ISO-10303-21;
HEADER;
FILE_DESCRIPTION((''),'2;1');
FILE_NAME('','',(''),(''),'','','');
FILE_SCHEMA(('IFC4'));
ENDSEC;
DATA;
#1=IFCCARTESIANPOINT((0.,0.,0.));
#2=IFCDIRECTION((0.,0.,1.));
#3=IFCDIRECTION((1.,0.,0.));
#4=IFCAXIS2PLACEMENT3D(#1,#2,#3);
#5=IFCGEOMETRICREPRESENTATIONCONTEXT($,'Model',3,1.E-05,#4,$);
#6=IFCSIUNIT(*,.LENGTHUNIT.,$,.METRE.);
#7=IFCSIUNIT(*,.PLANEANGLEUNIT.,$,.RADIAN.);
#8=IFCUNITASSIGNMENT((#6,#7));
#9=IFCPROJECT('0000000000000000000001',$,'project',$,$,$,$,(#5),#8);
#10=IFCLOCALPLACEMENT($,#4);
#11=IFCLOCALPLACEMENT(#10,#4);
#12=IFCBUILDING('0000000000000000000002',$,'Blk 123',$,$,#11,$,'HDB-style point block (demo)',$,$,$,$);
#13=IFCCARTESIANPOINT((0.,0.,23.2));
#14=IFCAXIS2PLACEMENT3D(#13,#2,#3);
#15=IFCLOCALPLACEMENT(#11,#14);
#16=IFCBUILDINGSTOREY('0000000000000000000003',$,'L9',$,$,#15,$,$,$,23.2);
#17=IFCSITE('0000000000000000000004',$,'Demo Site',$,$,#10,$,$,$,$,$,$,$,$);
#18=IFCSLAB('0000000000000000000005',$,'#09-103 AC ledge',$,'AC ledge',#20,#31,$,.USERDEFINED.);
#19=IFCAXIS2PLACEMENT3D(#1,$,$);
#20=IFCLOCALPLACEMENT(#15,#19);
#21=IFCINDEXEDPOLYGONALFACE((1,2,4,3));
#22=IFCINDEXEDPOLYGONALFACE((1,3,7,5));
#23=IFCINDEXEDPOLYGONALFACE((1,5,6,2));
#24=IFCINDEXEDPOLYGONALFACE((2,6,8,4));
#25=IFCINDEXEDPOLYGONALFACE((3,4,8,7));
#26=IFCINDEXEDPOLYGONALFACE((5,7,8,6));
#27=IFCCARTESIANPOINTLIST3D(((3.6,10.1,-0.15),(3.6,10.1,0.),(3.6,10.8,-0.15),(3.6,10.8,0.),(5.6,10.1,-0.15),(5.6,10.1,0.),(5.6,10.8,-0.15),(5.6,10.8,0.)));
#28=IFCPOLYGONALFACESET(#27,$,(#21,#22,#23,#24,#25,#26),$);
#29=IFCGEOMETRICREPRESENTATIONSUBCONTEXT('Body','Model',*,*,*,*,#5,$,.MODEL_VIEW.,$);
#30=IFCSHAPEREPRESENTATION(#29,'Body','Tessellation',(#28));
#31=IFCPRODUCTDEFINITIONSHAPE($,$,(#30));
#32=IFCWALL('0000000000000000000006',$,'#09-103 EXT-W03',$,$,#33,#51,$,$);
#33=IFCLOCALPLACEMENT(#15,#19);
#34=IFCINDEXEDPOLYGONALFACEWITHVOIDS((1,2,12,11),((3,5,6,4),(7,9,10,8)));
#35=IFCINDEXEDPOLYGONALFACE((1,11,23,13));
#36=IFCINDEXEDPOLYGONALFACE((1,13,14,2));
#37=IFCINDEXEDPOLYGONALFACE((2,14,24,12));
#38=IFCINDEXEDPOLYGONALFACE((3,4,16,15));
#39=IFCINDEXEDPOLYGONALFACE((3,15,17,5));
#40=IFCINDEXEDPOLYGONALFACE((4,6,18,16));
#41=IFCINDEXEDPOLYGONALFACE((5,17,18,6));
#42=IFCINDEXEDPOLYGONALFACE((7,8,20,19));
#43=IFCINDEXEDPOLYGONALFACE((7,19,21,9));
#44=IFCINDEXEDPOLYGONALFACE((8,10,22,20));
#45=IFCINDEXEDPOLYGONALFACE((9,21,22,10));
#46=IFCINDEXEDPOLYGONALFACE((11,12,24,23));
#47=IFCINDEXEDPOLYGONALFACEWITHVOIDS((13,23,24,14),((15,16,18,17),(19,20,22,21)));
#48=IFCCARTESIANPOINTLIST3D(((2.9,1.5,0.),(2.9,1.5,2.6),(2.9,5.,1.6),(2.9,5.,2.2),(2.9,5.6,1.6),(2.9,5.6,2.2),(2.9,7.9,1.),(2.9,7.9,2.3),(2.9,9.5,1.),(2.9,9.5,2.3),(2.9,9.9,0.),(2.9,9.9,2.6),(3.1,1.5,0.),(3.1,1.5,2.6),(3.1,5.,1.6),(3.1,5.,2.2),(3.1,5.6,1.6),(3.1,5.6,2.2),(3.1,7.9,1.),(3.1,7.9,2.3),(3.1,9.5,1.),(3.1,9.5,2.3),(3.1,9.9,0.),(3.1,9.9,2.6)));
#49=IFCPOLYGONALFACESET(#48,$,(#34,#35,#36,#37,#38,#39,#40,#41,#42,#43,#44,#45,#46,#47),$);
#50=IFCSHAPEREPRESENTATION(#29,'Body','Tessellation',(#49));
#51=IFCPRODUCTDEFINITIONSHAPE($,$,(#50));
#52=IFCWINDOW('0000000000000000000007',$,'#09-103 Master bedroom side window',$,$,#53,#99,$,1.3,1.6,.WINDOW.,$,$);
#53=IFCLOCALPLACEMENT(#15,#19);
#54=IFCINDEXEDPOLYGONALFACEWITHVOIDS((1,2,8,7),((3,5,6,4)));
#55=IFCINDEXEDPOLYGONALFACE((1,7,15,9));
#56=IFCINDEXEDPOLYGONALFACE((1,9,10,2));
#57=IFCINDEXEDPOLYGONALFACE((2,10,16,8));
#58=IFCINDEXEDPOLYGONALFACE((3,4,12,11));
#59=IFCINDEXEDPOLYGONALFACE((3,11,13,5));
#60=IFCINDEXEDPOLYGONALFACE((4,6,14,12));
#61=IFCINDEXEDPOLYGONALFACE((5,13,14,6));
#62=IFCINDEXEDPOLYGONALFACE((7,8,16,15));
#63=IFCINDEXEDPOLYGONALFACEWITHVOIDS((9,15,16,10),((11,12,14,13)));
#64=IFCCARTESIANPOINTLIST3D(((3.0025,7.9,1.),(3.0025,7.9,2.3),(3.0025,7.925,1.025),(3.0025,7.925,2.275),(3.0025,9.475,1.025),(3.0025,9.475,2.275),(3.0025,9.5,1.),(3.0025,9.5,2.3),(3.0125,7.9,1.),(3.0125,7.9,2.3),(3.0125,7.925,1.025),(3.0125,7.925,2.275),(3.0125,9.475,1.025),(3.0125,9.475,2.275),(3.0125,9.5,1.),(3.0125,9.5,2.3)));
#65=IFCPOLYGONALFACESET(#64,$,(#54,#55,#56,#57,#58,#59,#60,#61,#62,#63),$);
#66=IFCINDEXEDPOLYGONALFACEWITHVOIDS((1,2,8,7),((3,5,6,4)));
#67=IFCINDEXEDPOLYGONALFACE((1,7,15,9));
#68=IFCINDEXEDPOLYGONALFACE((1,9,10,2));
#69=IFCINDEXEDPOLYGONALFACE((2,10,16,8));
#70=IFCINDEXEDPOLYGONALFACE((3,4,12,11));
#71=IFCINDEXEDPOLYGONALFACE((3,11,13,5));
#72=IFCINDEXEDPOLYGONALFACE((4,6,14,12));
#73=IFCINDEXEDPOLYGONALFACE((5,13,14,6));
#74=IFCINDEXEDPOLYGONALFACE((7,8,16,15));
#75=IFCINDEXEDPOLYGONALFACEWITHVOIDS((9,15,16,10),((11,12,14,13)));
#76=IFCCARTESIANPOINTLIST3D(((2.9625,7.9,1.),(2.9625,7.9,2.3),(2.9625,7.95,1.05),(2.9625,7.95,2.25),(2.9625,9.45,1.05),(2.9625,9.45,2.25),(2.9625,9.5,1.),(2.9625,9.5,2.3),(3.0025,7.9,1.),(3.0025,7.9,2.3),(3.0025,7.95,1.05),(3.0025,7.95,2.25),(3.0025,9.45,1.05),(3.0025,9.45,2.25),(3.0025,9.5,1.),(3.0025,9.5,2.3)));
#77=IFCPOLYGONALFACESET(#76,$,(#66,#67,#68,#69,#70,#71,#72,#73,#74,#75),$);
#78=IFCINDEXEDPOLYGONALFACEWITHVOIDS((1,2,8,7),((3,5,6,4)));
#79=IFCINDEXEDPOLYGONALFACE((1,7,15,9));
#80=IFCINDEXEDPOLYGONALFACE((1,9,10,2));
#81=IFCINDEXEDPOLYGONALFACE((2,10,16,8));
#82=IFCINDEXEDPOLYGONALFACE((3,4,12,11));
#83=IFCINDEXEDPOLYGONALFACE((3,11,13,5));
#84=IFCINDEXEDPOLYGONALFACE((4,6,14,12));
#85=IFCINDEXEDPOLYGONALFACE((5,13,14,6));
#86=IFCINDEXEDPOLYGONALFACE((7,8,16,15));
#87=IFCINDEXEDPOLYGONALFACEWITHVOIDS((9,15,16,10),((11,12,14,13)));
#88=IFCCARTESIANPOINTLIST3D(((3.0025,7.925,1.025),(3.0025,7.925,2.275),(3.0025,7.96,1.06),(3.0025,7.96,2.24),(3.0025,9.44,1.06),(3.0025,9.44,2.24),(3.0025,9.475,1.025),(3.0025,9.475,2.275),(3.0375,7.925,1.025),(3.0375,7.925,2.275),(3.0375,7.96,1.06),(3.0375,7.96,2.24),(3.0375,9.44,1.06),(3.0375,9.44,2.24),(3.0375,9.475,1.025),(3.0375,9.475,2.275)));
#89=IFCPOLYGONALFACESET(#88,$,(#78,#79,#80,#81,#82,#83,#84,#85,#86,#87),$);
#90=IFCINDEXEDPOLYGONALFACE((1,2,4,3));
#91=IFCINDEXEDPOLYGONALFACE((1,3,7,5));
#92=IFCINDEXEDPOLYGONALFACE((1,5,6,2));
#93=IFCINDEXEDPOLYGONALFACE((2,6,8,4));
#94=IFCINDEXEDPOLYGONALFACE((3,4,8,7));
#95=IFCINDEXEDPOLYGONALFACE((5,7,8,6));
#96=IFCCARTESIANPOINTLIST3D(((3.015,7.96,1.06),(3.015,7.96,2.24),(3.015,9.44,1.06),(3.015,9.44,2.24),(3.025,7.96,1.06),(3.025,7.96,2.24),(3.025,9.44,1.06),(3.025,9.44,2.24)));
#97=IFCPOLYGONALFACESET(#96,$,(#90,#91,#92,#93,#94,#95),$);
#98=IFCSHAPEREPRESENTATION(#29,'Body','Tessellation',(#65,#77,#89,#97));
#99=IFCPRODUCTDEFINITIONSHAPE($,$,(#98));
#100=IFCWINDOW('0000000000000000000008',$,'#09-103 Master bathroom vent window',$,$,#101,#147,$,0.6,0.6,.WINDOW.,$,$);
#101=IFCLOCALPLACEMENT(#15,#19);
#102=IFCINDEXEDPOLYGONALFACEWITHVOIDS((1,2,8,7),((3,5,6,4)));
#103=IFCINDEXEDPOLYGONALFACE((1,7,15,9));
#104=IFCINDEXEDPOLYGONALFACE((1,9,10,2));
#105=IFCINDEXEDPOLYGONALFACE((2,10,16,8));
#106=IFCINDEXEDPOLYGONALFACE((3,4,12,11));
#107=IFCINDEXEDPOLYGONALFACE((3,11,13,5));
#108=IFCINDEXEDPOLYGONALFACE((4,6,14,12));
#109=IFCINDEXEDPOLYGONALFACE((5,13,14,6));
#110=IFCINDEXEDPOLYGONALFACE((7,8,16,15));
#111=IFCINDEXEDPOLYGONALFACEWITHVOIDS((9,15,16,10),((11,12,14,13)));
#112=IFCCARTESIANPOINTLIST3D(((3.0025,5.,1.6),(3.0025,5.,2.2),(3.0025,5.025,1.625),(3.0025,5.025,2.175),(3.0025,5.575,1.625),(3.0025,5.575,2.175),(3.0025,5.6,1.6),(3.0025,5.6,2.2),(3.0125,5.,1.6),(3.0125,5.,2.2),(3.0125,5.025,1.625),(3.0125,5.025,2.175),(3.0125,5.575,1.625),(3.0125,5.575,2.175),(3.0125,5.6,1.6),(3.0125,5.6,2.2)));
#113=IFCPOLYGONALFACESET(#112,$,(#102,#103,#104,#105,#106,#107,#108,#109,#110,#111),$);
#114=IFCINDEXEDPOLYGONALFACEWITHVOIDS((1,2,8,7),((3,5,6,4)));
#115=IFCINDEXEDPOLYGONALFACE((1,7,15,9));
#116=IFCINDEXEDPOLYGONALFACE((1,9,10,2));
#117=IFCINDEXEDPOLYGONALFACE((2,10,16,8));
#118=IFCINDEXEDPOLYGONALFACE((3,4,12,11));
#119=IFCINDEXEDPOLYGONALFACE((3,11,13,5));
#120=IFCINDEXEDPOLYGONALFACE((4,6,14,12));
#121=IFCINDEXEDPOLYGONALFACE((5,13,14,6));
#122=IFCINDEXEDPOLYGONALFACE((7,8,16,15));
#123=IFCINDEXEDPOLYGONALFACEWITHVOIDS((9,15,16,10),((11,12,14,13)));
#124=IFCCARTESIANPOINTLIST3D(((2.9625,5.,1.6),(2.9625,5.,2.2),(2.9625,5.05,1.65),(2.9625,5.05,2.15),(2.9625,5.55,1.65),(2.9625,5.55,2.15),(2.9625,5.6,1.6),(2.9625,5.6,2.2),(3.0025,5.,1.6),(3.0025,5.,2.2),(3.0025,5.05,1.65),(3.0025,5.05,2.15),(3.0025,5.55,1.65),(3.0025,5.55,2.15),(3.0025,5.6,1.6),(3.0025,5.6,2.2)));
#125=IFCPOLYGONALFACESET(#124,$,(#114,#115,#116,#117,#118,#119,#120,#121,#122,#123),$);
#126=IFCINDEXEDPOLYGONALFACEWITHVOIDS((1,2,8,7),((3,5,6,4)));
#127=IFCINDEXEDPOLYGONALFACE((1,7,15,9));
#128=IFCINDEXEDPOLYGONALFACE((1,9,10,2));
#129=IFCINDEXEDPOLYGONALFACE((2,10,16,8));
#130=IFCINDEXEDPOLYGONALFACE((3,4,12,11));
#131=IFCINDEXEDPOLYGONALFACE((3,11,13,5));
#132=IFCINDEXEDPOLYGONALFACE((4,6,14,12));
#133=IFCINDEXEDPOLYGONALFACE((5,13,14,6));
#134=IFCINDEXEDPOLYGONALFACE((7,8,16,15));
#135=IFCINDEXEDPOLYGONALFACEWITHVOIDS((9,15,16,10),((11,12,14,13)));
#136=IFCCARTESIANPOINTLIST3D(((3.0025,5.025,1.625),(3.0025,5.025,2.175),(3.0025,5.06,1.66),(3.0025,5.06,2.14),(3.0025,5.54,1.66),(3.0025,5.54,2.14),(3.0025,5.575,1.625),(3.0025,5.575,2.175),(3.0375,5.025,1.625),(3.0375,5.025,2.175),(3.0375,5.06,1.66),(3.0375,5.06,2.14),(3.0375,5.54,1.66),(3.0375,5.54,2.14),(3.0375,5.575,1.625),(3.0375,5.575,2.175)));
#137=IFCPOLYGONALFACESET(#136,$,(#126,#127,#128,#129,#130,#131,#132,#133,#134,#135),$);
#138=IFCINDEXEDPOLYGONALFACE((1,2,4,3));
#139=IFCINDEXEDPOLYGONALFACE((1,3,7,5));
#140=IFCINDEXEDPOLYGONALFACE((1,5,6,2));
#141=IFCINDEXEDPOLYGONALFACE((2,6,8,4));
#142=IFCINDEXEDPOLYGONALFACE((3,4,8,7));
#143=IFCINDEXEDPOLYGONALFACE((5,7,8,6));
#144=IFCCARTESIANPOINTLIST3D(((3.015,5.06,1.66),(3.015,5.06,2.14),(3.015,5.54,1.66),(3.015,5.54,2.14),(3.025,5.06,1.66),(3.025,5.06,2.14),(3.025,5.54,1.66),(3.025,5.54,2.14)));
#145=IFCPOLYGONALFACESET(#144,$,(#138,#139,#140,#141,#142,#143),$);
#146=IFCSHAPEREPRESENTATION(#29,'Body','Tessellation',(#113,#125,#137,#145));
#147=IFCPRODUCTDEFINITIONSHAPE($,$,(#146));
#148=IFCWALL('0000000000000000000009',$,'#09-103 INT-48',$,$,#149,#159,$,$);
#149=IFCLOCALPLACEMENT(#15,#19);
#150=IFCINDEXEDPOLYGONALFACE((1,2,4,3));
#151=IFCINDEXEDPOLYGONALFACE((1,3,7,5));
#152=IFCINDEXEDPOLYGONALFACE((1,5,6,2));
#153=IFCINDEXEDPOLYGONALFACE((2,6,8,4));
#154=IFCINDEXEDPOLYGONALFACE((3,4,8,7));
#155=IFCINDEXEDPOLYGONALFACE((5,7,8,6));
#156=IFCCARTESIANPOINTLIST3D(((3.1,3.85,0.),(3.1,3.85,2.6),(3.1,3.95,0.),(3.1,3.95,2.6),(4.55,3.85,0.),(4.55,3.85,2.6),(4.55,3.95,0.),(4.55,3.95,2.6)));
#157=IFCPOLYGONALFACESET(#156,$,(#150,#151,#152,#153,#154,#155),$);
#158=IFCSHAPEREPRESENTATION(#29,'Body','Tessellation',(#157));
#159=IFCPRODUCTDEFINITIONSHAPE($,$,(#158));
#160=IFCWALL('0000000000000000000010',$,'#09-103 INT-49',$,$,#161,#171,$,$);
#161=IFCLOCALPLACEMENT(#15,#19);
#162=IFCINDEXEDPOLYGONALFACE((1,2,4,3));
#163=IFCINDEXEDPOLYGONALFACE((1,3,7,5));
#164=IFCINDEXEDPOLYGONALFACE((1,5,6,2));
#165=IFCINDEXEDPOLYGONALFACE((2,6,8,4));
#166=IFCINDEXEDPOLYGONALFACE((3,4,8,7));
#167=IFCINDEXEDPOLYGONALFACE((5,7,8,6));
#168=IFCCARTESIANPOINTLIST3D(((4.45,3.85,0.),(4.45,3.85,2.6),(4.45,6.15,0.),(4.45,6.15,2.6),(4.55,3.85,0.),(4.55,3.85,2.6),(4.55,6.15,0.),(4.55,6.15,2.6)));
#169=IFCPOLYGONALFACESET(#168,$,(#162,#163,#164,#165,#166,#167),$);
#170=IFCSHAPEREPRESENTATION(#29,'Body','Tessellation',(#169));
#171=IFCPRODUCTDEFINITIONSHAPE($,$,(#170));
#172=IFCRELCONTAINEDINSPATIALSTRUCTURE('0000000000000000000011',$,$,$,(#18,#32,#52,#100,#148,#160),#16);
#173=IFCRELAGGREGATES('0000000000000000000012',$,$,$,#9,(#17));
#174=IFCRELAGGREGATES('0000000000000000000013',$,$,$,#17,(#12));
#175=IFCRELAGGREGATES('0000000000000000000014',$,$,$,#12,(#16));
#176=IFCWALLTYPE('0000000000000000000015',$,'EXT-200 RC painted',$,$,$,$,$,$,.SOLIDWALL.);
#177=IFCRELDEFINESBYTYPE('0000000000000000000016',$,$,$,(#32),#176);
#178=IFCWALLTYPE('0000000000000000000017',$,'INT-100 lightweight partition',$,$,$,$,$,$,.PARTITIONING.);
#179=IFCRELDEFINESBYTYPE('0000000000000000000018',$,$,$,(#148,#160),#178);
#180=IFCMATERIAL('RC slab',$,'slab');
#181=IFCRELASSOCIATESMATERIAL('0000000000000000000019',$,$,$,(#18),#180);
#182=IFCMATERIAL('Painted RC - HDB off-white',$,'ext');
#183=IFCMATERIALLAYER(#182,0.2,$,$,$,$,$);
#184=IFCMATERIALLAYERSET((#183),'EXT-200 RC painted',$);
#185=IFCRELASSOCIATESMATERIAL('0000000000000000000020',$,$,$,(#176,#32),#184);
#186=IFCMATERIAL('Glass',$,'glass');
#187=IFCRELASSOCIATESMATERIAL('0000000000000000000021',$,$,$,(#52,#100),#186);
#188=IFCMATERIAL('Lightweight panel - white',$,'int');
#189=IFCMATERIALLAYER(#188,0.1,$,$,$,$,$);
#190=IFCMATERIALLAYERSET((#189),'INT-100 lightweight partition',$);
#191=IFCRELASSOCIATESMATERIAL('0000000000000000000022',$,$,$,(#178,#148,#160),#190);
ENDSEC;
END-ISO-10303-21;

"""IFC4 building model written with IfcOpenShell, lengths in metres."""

from ifc_helpers import new_model, si_unit, frame, origin, origin_with_axes, place, context, subcontext, project, spatial, polyline, line, indexed_curve, outline, extrude, material, layer, layer_set, layer_usage, type_object, element, fill, save


model = new_model("IFC4")

# Units and contexts
model_context = context("Model", 3, precision=1e-05, world=origin_with_axes())
body_context = subcontext(model_context, "Body", "Model", "MODEL_VIEW")
ifc_project = project(units=[si_unit("LENGTHUNIT", "METRE"), si_unit("PLANEANGLEUNIT", "RADIAN")], contexts=[model_context])

# Site, building, storey
site_placement = place(None, origin_with_axes())
site = spatial("IfcSite", under=ifc_project, at=site_placement, Name="Demo Site")
building_placement = place(site_placement, origin_with_axes())
building = spatial("IfcBuilding", under=site, at=building_placement, Name="Blk 123", LongName="HDB-style point block (demo)")
storey_placement = place(building_placement, frame((0.0, 0.0, 23.2), z_axis=(0.0, 0.0, 1.0), x_axis=(1.0, 0.0, 0.0)))
storey = spatial("IfcBuildingStorey", under=building, at=storey_placement, Name="L9", Elevation=23.2)

# Slab
ifc_material_1 = material(Name="RC slab", Category="slab")
slab_placement = place(storey_placement, frame((4.6, 10.45, -0.15), z_axis=(0.0, 0.0, 1.0), x_axis=(1.0, 0.0, 0.0)))
element("IfcSlab", 1, at=slab_placement, inside=storey, material=ifc_material_1, Name="#09-103 AC ledge", ObjectType="AC ledge", PredefinedType="USERDEFINED", context=body_context, shape_type="SweptSolid", body=[
    extrude(outline(polyline([(1.0, -0.35), (1.0, 0.35), (-1.0, 0.35), (-1.0, -0.35), (1.0, -0.35)])), origin(), (0.0, 0.0, 1.0), 0.15),
])

# Wall, openings, windows
ifc_material_2 = material(Name="Painted RC - HDB off-white", Category="ext")
ifc_layer_1 = layer(ifc_material_2, 0.2)
ifc_layer_set_1 = layer_set([ifc_layer_1], Name="EXT-200 RC painted")
ifc_layer_usage_1 = layer_usage(ifc_layer_set_1, "AXIS2", "POSITIVE", 0.0)
wall_type_1 = type_object("IfcWallType", Name="EXT-200 RC painted", PredefinedType="SOLIDWALL", material=ifc_layer_set_1)
wall_1_placement = place(storey_placement, frame((2.9, 9.9, 0.0), z_axis=(0.0, 0.0, 1.0), x_axis=(0.0, -1.0, 0.0)))
wall_1 = element("IfcWall", 2, at=wall_1_placement, inside=storey, type_object=wall_type_1, material=ifc_layer_usage_1, Name="#09-103 EXT-W03", context=body_context, shape_type="SweptSolid", body=[
    extrude(outline(indexed_curve([(0.0, 0.0), (0.0, 0.2), (8.4, 0.2), (8.4, 0.0), (0.0, 0.0)], self_intersect=False)), origin_with_axes(), (0.0, 0.0, 1.0), 2.6),
])
opening_1_placement = place(wall_1_placement, frame((0.4, -0.1, 1.0), z_axis=(0.0, 0.0, 1.0), x_axis=(1.0, 0.0, 0.0)))
opening_1 = element("IfcOpeningElement", 3, at=opening_1_placement, cuts=wall_1, context=body_context, shape_type="SweptSolid", body=[
    extrude(outline(indexed_curve([(0.0, 0.0), (0.0, 0.4), (1.6, 0.4), (1.6, 0.0), (0.0, 0.0)], self_intersect=False)), origin_with_axes(), (0.0, 0.0, 1.0), 1.3),
])
opening_2_placement = place(wall_1_placement, frame((4.3, -0.1, 1.6), z_axis=(0.0, 0.0, 1.0), x_axis=(1.0, 0.0, 0.0)))
opening_2 = element("IfcOpeningElement", 4, at=opening_2_placement, cuts=wall_1, context=body_context, shape_type="SweptSolid", body=[
    extrude(outline(indexed_curve([(0.0, 0.0), (0.0, 0.4), (0.6, 0.4), (0.6, 0.0), (0.0, 0.0)], self_intersect=False)), origin_with_axes(), (0.0, 0.0, 1.0), 0.6),
])
ifc_material_3 = material(Name="Glass", Category="glass")
window_1_placement = place(opening_1_placement, frame((0.0, 0.1125, 0.0), z_axis=(0.0, 0.0, 1.0), x_axis=(1.0, 0.0, 0.0)))
window_1 = element("IfcWindow", 5, at=window_1_placement, inside=storey, material=ifc_material_3, Name="#09-103 Master bedroom side window", OverallHeight=1.3, OverallWidth=1.6, PredefinedType="WINDOW", context=body_context, shape_type="SweptSolid", body=[
    extrude(outline(indexed_curve([(0.0, 0.0), (1.6, 0.0), (1.6, 1.3), (0.0, 1.3)], segments=[line(1, 2, 3, 4, 1)]), holes=[indexed_curve([(0.025, 0.025), (1.575, 0.025), (1.575, 1.275), (0.025, 1.275)], segments=[line(1, 2, 3, 4, 1)])]), frame((0.0, 0.09, 0.0), z_axis=(0.0, -1.0, 0.0), x_axis=(1.0, 0.0, 0.0)), (0.0, 0.0, -1.0), 0.01),
    extrude(outline(indexed_curve([(0.0, 0.0), (1.6, 0.0), (1.6, 1.3), (0.0, 1.3)], segments=[line(1, 2, 3, 4, 1)]), holes=[indexed_curve([(0.05, 0.05), (1.55, 0.05), (1.55, 1.25), (0.05, 1.25)], segments=[line(1, 2, 3, 4, 1)])]), frame((0.0, 0.05, 0.0), z_axis=(0.0, -1.0, 0.0), x_axis=(1.0, 0.0, 0.0)), (0.0, 0.0, -1.0), 0.04),
    extrude(outline(indexed_curve([(0.0, 0.0), (1.55, 0.0), (1.55, 1.25), (0.0, 1.25)], segments=[line(1, 2, 3, 4, 1)]), holes=[indexed_curve([(0.035, 0.035), (1.515, 0.035), (1.515, 1.215), (0.035, 1.215)], segments=[line(1, 2, 3, 4, 1)])]), frame((0.025, 0.09, 0.025), z_axis=(0.0, -1.0, 0.0), x_axis=(1.0, 0.0, 0.0)), (0.0, 0.0, -1.0), 0.035),
    extrude(outline(indexed_curve([(0.035, 0.035), (1.515, 0.035), (1.515, 1.215), (0.035, 1.215)], segments=[line(1, 2, 3, 4, 1)])), frame((0.025, 0.1025, 0.025), z_axis=(0.0, -1.0, 0.0), x_axis=(1.0, 0.0, 0.0)), (0.0, 0.0, -1.0), 0.01),
])
fill(opening_1, window_1)
window_2_placement = place(opening_2_placement, frame((0.0, 0.1125, 0.0), z_axis=(0.0, 0.0, 1.0), x_axis=(1.0, 0.0, 0.0)))
window_2 = element("IfcWindow", 6, at=window_2_placement, inside=storey, material=ifc_material_3, Name="#09-103 Master bathroom vent window", OverallHeight=0.6, OverallWidth=0.6, PredefinedType="WINDOW", context=body_context, shape_type="SweptSolid", body=[
    extrude(outline(indexed_curve([(0.0, 0.0), (0.6, 0.0), (0.6, 0.6), (0.0, 0.6)], segments=[line(1, 2, 3, 4, 1)]), holes=[indexed_curve([(0.025, 0.025), (0.575, 0.025), (0.575, 0.575), (0.025, 0.575)], segments=[line(1, 2, 3, 4, 1)])]), frame((0.0, 0.09, 0.0), z_axis=(0.0, -1.0, 0.0), x_axis=(1.0, 0.0, 0.0)), (0.0, 0.0, -1.0), 0.01),
    extrude(outline(indexed_curve([(0.0, 0.0), (0.6, 0.0), (0.6, 0.6), (0.0, 0.6)], segments=[line(1, 2, 3, 4, 1)]), holes=[indexed_curve([(0.05, 0.05), (0.55, 0.05), (0.55, 0.55), (0.05, 0.55)], segments=[line(1, 2, 3, 4, 1)])]), frame((0.0, 0.05, 0.0), z_axis=(0.0, -1.0, 0.0), x_axis=(1.0, 0.0, 0.0)), (0.0, 0.0, -1.0), 0.04),
    extrude(outline(indexed_curve([(0.0, 0.0), (0.55, 0.0), (0.55, 0.55), (0.0, 0.55)], segments=[line(1, 2, 3, 4, 1)]), holes=[indexed_curve([(0.035, 0.035), (0.515, 0.035), (0.515, 0.515), (0.035, 0.515)], segments=[line(1, 2, 3, 4, 1)])]), frame((0.025, 0.09, 0.025), z_axis=(0.0, -1.0, 0.0), x_axis=(1.0, 0.0, 0.0)), (0.0, 0.0, -1.0), 0.035),
    extrude(outline(indexed_curve([(0.035, 0.035), (0.515, 0.035), (0.515, 0.515), (0.035, 0.515)], segments=[line(1, 2, 3, 4, 1)])), frame((0.025, 0.1025, 0.025), z_axis=(0.0, -1.0, 0.0), x_axis=(1.0, 0.0, 0.0)), (0.0, 0.0, -1.0), 0.01),
])
fill(opening_2, window_2)

# Shared definitions
ifc_material_4 = material(Name="Lightweight panel - white", Category="int")
ifc_layer_2 = layer(ifc_material_4, 0.1)
ifc_layer_set_2 = layer_set([ifc_layer_2], Name="INT-100 lightweight partition")
ifc_layer_usage_2 = layer_usage(ifc_layer_set_2, "AXIS2", "POSITIVE", -0.05)
wall_type_2 = type_object("IfcWallType", Name="INT-100 lightweight partition", PredefinedType="PARTITIONING", material=ifc_layer_set_2)

# Walls
wall_2_placement = place(storey_placement, frame((3.1, 3.9, 0.0), z_axis=(0.0, 0.0, 1.0), x_axis=(1.0, 0.0, 0.0)))
element("IfcWall", 7, at=wall_2_placement, inside=storey, type_object=wall_type_2, material=ifc_layer_usage_2, Name="#09-103 INT-48", context=body_context, shape_type="SweptSolid", body=[
    extrude(outline(indexed_curve([(0.0, 0.0), (0.0, 0.1), (1.45, 0.1), (1.45, 0.0), (0.0, 0.0)], self_intersect=False)), frame((0.0, -0.05, 0.0), z_axis=(0.0, 0.0, 1.0), x_axis=(1.0, 0.0, 0.0)), (0.0, 0.0, 1.0), 2.6),
])
wall_3_placement = place(storey_placement, frame((4.5, 3.85, 0.0), z_axis=(0.0, 0.0, 1.0), x_axis=(0.0, 1.0, 0.0)))
element("IfcWall", 8, at=wall_3_placement, inside=storey, type_object=wall_type_2, material=ifc_layer_usage_2, Name="#09-103 INT-49", context=body_context, shape_type="SweptSolid", body=[
    extrude(outline(indexed_curve([(0.0, 0.0), (0.0, 0.1), (2.3, 0.1), (2.3, 0.0), (0.0, 0.0)], self_intersect=False)), frame((0.0, -0.05, 0.0), z_axis=(0.0, 0.0, 1.0), x_axis=(1.0, 0.0, 0.0)), (0.0, 0.0, 1.0), 2.6),
])

save(model, "model.ifc")
